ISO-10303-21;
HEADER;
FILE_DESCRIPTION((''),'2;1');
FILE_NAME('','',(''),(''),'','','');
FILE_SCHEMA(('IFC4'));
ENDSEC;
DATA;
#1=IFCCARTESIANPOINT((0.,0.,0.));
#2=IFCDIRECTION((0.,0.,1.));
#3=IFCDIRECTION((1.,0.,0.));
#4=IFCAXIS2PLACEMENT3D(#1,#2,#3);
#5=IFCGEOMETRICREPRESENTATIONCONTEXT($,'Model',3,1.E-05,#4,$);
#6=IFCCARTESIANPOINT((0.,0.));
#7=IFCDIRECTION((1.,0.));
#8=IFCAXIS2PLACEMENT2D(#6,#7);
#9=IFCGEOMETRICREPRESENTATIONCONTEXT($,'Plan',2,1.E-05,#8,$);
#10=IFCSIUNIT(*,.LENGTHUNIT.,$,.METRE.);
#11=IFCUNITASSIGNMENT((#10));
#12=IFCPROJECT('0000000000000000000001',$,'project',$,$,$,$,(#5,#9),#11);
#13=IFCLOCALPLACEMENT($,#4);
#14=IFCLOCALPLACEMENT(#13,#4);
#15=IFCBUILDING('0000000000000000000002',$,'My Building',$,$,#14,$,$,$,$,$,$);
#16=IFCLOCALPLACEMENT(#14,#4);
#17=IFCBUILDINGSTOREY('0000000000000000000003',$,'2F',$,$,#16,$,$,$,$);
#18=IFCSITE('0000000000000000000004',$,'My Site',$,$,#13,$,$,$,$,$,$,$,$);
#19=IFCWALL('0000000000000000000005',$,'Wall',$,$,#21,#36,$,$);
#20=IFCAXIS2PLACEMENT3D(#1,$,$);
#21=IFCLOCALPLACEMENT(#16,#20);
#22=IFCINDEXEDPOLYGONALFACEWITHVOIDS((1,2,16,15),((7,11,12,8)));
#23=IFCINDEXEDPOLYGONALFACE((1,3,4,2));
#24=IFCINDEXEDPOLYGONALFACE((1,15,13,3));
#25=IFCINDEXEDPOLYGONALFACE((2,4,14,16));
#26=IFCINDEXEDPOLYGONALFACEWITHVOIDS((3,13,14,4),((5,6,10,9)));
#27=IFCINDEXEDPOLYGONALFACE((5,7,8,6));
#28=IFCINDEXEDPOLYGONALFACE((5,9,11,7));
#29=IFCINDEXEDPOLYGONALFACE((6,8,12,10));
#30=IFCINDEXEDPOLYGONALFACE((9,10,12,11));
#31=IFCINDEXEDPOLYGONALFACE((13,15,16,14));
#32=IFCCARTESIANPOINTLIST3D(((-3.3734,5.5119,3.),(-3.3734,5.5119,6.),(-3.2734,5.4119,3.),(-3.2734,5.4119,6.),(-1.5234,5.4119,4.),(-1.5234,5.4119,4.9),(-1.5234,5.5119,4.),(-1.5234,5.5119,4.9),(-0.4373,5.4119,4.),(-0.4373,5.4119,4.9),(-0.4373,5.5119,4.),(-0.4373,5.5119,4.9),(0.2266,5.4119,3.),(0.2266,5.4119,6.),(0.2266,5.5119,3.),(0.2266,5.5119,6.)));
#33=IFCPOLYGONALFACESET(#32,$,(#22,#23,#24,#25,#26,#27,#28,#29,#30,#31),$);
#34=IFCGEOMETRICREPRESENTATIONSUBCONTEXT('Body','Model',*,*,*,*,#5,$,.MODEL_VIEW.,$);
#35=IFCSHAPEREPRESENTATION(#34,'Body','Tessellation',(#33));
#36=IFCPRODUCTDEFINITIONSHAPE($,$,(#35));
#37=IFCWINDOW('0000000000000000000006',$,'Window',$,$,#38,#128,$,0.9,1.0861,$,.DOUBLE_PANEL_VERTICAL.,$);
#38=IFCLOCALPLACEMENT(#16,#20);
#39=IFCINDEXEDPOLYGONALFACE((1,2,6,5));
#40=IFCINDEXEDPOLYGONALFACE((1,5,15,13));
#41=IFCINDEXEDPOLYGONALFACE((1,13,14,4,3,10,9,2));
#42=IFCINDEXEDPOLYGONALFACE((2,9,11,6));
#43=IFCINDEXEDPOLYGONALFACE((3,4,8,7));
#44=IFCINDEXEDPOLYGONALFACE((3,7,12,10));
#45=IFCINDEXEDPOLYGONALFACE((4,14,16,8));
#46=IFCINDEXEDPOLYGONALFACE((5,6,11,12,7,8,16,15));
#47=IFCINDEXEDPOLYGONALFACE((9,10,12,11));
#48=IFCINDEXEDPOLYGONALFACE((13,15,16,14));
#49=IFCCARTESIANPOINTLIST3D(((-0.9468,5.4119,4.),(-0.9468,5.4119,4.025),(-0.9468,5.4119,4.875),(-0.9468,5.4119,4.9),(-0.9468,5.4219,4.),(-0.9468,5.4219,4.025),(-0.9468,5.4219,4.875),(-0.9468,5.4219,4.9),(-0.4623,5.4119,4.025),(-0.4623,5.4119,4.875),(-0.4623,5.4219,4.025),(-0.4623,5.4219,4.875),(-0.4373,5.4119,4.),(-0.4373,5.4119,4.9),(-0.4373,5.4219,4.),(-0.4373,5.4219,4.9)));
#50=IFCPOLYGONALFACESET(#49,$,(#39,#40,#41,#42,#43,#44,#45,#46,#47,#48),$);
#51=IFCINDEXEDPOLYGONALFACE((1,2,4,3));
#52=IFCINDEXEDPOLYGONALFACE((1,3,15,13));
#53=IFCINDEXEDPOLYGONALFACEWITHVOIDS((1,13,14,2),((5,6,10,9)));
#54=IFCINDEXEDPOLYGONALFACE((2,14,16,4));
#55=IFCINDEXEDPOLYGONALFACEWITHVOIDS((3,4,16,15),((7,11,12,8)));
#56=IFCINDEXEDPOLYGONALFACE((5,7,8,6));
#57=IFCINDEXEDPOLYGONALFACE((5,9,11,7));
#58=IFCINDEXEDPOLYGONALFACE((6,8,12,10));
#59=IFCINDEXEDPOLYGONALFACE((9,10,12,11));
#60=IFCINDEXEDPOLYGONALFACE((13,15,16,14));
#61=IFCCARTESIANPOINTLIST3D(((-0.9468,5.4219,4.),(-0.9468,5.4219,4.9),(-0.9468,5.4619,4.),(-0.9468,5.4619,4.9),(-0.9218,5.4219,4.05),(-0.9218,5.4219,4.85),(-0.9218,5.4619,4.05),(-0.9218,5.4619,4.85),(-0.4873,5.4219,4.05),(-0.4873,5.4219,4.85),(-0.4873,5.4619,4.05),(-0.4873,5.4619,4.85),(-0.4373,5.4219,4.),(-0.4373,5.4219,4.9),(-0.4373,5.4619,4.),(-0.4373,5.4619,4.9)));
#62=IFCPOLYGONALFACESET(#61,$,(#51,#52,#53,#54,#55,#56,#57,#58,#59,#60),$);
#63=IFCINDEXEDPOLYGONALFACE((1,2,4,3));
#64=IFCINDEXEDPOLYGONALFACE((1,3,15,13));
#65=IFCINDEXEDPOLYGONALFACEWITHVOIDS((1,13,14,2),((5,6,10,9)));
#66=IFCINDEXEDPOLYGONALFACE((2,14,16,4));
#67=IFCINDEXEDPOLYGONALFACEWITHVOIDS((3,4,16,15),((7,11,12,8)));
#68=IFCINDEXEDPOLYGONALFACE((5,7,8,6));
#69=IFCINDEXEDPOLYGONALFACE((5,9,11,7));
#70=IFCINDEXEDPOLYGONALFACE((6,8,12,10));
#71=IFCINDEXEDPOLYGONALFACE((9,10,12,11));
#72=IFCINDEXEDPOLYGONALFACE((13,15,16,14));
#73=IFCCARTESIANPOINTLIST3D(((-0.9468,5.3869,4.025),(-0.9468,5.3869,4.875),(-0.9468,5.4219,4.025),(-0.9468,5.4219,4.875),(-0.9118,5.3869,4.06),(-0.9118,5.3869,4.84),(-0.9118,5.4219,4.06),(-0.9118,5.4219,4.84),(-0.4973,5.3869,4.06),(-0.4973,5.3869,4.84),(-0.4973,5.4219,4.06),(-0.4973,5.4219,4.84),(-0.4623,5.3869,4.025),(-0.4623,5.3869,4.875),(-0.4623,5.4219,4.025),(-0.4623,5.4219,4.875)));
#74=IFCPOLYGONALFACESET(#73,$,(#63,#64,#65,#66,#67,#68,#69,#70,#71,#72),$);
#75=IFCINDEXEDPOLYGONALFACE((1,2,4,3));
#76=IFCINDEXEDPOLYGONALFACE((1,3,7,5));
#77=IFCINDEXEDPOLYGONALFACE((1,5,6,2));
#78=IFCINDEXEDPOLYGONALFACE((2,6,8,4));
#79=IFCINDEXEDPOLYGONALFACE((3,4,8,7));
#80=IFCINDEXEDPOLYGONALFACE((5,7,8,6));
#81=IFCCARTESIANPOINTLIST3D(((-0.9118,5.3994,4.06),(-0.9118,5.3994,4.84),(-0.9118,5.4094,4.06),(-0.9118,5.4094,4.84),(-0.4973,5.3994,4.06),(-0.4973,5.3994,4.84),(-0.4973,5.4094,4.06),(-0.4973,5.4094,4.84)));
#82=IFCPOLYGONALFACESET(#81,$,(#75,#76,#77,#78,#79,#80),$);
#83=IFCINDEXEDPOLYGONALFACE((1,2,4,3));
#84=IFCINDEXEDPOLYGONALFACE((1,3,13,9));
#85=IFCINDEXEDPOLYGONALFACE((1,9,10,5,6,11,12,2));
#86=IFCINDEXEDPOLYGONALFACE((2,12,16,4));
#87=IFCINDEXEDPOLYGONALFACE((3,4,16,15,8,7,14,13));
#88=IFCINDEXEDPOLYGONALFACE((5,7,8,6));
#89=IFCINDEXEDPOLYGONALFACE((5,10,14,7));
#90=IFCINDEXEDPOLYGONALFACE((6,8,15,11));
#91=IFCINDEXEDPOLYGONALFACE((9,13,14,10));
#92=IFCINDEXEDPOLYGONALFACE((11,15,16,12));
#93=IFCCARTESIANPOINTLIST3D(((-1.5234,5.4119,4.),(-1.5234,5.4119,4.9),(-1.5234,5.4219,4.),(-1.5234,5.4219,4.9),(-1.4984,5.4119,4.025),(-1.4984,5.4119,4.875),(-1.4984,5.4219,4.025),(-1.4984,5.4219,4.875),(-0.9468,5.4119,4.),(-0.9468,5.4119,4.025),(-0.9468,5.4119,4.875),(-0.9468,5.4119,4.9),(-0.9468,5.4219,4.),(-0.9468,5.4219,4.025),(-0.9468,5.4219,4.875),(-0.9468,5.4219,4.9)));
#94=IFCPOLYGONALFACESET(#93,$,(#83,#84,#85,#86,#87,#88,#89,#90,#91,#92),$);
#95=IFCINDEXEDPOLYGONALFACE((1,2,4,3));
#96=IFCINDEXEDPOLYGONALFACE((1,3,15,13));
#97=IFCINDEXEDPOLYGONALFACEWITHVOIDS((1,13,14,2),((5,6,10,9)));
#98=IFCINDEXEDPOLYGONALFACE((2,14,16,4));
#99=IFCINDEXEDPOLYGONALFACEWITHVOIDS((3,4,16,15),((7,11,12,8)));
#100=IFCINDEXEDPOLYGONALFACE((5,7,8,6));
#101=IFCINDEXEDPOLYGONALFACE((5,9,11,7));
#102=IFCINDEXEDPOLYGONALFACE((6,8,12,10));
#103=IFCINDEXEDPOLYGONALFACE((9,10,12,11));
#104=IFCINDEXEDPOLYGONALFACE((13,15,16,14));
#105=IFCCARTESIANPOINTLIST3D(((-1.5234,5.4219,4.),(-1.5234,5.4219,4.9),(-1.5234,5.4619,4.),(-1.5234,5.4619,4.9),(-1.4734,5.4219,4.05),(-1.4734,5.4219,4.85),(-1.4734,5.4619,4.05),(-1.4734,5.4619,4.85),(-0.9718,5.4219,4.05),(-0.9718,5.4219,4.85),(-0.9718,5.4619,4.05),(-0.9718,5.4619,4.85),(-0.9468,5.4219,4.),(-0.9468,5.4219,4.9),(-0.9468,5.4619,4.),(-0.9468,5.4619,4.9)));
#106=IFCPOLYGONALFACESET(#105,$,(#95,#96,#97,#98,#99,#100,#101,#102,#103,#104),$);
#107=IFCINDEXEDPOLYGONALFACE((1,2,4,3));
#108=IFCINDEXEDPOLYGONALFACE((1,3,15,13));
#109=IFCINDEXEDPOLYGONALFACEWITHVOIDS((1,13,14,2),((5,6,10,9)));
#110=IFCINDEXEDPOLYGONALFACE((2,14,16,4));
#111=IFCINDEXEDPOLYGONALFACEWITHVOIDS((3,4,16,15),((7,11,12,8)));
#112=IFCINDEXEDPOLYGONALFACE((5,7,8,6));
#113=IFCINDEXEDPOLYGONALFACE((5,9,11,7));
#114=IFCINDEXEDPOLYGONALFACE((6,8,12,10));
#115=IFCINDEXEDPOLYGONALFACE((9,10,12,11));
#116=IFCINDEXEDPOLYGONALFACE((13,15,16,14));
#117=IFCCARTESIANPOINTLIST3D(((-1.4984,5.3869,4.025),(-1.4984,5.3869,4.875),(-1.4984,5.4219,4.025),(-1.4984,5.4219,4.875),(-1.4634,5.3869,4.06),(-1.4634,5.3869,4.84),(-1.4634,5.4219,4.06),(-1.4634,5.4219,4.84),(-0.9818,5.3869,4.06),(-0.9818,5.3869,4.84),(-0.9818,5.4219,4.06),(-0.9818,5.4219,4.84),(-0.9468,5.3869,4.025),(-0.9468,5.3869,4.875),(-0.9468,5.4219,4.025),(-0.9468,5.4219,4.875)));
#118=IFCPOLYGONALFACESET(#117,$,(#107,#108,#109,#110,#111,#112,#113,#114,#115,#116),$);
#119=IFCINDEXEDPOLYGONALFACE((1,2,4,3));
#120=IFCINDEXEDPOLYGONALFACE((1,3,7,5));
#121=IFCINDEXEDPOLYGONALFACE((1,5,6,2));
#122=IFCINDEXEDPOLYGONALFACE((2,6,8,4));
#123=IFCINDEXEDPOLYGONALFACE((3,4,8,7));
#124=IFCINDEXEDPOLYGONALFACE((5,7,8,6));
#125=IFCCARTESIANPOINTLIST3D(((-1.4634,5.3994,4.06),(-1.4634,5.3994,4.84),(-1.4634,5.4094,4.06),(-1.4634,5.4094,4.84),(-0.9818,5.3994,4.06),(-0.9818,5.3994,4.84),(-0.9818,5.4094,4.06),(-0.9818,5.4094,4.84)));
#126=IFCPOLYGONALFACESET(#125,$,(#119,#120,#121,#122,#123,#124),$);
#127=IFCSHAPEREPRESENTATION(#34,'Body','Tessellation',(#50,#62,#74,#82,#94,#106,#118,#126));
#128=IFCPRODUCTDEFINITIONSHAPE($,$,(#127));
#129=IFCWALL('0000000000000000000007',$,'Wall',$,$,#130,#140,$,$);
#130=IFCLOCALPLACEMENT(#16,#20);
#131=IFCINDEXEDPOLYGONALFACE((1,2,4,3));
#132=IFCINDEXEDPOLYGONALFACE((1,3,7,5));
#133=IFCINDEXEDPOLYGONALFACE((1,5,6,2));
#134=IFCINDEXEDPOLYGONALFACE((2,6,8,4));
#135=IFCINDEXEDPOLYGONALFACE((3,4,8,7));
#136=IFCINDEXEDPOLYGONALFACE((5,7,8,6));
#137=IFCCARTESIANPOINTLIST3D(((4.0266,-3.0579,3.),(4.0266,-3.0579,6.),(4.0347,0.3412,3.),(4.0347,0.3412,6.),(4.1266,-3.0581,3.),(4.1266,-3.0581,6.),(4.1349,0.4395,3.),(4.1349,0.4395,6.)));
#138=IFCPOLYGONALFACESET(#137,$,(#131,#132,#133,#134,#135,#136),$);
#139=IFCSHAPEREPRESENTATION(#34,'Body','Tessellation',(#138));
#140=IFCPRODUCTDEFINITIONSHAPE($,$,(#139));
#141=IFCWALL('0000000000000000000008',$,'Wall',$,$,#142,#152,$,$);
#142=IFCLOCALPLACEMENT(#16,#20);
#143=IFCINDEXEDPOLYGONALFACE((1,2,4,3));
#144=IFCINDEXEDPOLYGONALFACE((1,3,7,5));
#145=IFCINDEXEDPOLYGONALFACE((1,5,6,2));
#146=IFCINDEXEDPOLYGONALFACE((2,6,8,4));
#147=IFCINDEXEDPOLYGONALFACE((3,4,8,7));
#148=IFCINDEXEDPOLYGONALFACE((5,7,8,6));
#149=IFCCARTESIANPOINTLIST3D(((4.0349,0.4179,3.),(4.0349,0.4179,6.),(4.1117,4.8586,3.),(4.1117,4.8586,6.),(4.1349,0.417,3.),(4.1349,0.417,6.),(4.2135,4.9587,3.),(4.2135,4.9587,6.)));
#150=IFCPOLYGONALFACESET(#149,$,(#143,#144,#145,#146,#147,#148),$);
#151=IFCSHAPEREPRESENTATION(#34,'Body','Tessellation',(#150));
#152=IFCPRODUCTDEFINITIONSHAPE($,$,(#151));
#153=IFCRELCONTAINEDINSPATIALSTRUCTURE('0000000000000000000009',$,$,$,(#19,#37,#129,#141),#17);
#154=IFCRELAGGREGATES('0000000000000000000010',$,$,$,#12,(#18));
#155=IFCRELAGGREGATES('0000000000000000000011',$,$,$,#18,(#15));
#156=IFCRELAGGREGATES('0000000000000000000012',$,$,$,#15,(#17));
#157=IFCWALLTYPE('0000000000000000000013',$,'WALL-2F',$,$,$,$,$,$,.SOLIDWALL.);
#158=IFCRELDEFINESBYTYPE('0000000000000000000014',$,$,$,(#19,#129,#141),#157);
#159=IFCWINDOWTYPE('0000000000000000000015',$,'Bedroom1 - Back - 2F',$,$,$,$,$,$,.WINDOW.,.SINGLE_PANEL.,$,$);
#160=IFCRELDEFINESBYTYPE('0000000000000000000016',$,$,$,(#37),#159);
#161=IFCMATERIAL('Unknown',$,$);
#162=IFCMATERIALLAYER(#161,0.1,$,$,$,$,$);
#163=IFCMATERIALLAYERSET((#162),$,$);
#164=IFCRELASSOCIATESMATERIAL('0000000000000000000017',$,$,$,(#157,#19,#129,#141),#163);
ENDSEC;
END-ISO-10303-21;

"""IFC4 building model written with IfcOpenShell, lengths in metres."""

from ifc_helpers import new_model, entity, si_unit, frame, origin_with_axes, origin_2d_with_axis, place, context, subcontext, project, spatial, line, indexed_curve, outline, extrude, shape, source, transform, mapped, material, layer, layer_set, layer_usage, type_object, type_shapes, element, fill, save


model = new_model("IFC4")

# Units and contexts
model_context = context("Model", 3, precision=1e-05, world=origin_with_axes())
plan_context = context("Plan", 2, precision=1e-05, world=origin_2d_with_axis())
body_context_1 = subcontext(model_context, "Body", "Model", "MODEL_VIEW")
body_context_2 = subcontext(plan_context, "Body", "Plan", "PLAN_VIEW")
ifc_project = project(units=[si_unit("LENGTHUNIT", "METRE")], contexts=[model_context, plan_context])

# Site, building, storey
site_placement = place(None, origin_with_axes())
site = spatial("IfcSite", under=ifc_project, at=site_placement, Name="My Site")
building_placement = place(site_placement, origin_with_axes())
building = spatial("IfcBuilding", under=site, at=building_placement, Name="My Building")
storey_placement = place(building_placement, origin_with_axes())
storey = spatial("IfcBuildingStorey", under=building, at=storey_placement, Name="2F")

# Shared definitions
ifc_material = material(Name="Unknown")
ifc_layer_1 = layer(ifc_material, 0.1)
ifc_layer_set_1 = layer_set([ifc_layer_1])
wall_type_1 = type_object("IfcWallType", Name="WALL-2F", PredefinedType="SOLIDWALL", material=ifc_layer_set_1)

# Wall, opening, window
ifc_layer_usage_1 = layer_usage(ifc_layer_set_1, "AXIS2", "POSITIVE", 0.0)
wall_1_placement = place(storey_placement, frame((0.2266, 5.5119, 3.0), z_axis=(0.0, 0.0, 1.0), x_axis=(-1.0, 0.0, 0.0)))
wall_1 = element("IfcWall", 1, at=wall_1_placement, inside=storey, type_object=wall_type_1, material=ifc_layer_usage_1, Name="Wall", context=body_context_1, shape_type="SweptSolid", body=[
    extrude(outline(indexed_curve([(0.0, 0.0), (0.0, 0.1), (3.5, 0.1), (3.6, 0.0)], segments=[line(1, 2, 3, 4, 1)])), origin_with_axes(), (0.0, 0.0, 1.0), 3.0),
])
shared_shape_1 = source(origin_with_axes(), body_context_1, "Body", "SweptSolid", [
    extrude(outline(indexed_curve([(0.0, 0.0), (1.0861, 0.0), (1.0861, 0.9), (0.0, 0.9)], segments=[line(1, 2, 3, 4, 1)])), frame((0.0, -0.6, 0.0), z_axis=(0.0, -1.0, 0.0), x_axis=(1.0, 0.0, 0.0)), (0.0, 0.0, -1.0), 1.2),
])
opening_1_placement = place(wall_1_placement, frame((0.6639, 0.0, 1.0), z_axis=(0.0, 0.0, 1.0), x_axis=(1.0, 0.0, 0.0)))
opening_1 = element("IfcOpeningElement", 2, at=opening_1_placement, cuts=wall_1, PredefinedType="OPENING", context=body_context_1, shape_type="MappedRepresentation", body=[
    mapped(shared_shape_1, transform((0.0, 0.0, 0.0), x_axis=(1.0, 0.0, 0.0), y_axis=(0.0, 1.0, 0.0), z_axis=(0.0, 0.0, 1.0), scale=1.0)),
])
window_type_1 = type_object("IfcWindowType", Name="Bedroom1 - Back - 2F", PartitioningType="SINGLE_PANEL", PredefinedType="WINDOW")
shared_shape_2 = source(origin_with_axes(), body_context_1, "Body", "SweptSolid", [
    extrude(outline(indexed_curve([(0.5096, 0.0), (0.0, 0.0), (0.0, 0.9), (0.5096, 0.9), (0.5096, 0.875), (0.025, 0.875), (0.025, 0.025), (0.5096, 0.025)], segments=[line(1, 2, 3, 4, 5, 6, 7, 8, 1)])), frame((0.0, 0.09, 0.0), z_axis=(0.0, -1.0, 0.0), x_axis=(1.0, 0.0, 0.0)), (0.0, 0.0, -1.0), 0.01),
    extrude(outline(indexed_curve([(0.0, 0.0), (0.5096, 0.0), (0.5096, 0.9), (0.0, 0.9)], segments=[line(1, 2, 3, 4, 1)]), holes=[indexed_curve([(0.05, 0.05), (0.4846, 0.05), (0.4846, 0.85), (0.05, 0.85)], segments=[line(1, 2, 3, 4, 1)])]), frame((0.0, 0.05, 0.0), z_axis=(0.0, -1.0, 0.0), x_axis=(1.0, 0.0, 0.0)), (0.0, 0.0, -1.0), 0.04),
    extrude(outline(indexed_curve([(0.0, 0.0), (0.4846, 0.0), (0.4846, 0.85), (0.0, 0.85)], segments=[line(1, 2, 3, 4, 1)]), holes=[indexed_curve([(0.035, 0.035), (0.4496, 0.035), (0.4496, 0.815), (0.035, 0.815)], segments=[line(1, 2, 3, 4, 1)])]), frame((0.025, 0.09, 0.025), z_axis=(0.0, -1.0, 0.0), x_axis=(1.0, 0.0, 0.0)), (0.0, 0.0, -1.0), 0.035),
    extrude(outline(indexed_curve([(0.035, 0.035), (0.4496, 0.035), (0.4496, 0.815), (0.035, 0.815)], segments=[line(1, 2, 3, 4, 1)])), frame((0.025, 0.1025, 0.025), z_axis=(0.0, -1.0, 0.0), x_axis=(1.0, 0.0, 0.0)), (0.0, 0.0, -1.0), 0.01),
    extrude(outline(indexed_curve([(0.0, 0.9), (0.5766, 0.9), (0.5766, 0.0), (0.0, 0.0), (0.0, 0.025), (0.5516, 0.025), (0.5516, 0.875), (0.0, 0.875)], segments=[line(1, 2, 3, 4, 5, 6, 7, 8, 1)])), frame((0.5096, 0.09, 0.0), z_axis=(0.0, -1.0, 0.0), x_axis=(1.0, 0.0, 0.0)), (0.0, 0.0, -1.0), 0.01),
    extrude(outline(indexed_curve([(0.0, 0.0), (0.5766, 0.0), (0.5766, 0.9), (0.0, 0.9)], segments=[line(1, 2, 3, 4, 1)]), holes=[indexed_curve([(0.025, 0.05), (0.5266, 0.05), (0.5266, 0.85), (0.025, 0.85)], segments=[line(1, 2, 3, 4, 1)])]), frame((0.5096, 0.05, 0.0), z_axis=(0.0, -1.0, 0.0), x_axis=(1.0, 0.0, 0.0)), (0.0, 0.0, -1.0), 0.04),
    extrude(outline(indexed_curve([(0.0, 0.0), (0.5516, 0.0), (0.5516, 0.85), (0.0, 0.85)], segments=[line(1, 2, 3, 4, 1)]), holes=[indexed_curve([(0.035, 0.035), (0.5166, 0.035), (0.5166, 0.815), (0.035, 0.815)], segments=[line(1, 2, 3, 4, 1)])]), frame((0.5096, 0.09, 0.025), z_axis=(0.0, -1.0, 0.0), x_axis=(1.0, 0.0, 0.0)), (0.0, 0.0, -1.0), 0.035),
    extrude(outline(indexed_curve([(0.035, 0.035), (0.5166, 0.035), (0.5166, 0.815), (0.035, 0.815)], segments=[line(1, 2, 3, 4, 1)])), frame((0.5096, 0.1025, 0.025), z_axis=(0.0, -1.0, 0.0), x_axis=(1.0, 0.0, 0.0)), (0.0, 0.0, -1.0), 0.01),
])
shared_shape_3 = source(origin_with_axes(), body_context_2, "Body", "Curve2D", [
    entity("IfcIndexedPolyCurve", entity("IfcCartesianPointList2D", [[0.05, 0.05], [0.4846, 0.05]])),
    entity("IfcIndexedPolyCurve", entity("IfcCartesianPointList2D", [[0.0, 0.1], [0.025, 0.1], [0.025, 0.09], [0.05, 0.09], [0.05, 0.05], [0.0, 0.05]]), [entity("IfcLineIndex", [1, 2, 3, 4, 5, 6, 1])]),
    entity("IfcIndexedPolyCurve", entity("IfcCartesianPointList2D", [[0.5096, 0.1], [0.5096, 0.1], [0.5096, 0.09], [0.4846, 0.09], [0.4846, 0.05], [0.5096, 0.05]])),
    entity("IfcIndexedPolyCurve", entity("IfcCartesianPointList2D", [[0.025, 0.09], [0.06, 0.09], [0.06, 0.125], [0.025, 0.125]]), [entity("IfcLineIndex", [1, 2, 3, 4, 1])]),
    entity("IfcIndexedPolyCurve", entity("IfcCartesianPointList2D", [[0.5096, 0.09], [0.4746, 0.09], [0.4746, 0.125], [0.5096, 0.125]]), [entity("IfcLineIndex", [1, 2, 3, 4, 1])]),
    entity("IfcIndexedPolyCurve", entity("IfcCartesianPointList2D", [[0.06, 0.09], [0.4746, 0.09]])),
    entity("IfcIndexedPolyCurve", entity("IfcCartesianPointList2D", [[0.06, 0.125], [0.4746, 0.125]])),
    entity("IfcIndexedPolyCurve", entity("IfcCartesianPointList2D", [[0.06, 0.1075], [0.4746, 0.1075]])),
    entity("IfcIndexedPolyCurve", entity("IfcCartesianPointList2D", [[0.5346, 0.05], [1.0361, 0.05]])),
    entity("IfcIndexedPolyCurve", entity("IfcCartesianPointList2D", [[0.5096, 0.1], [0.5096, 0.1], [0.5096, 0.09], [0.5346, 0.09], [0.5346, 0.05], [0.5096, 0.05]])),
    entity("IfcIndexedPolyCurve", entity("IfcCartesianPointList2D", [[1.0861, 0.1], [1.0611, 0.1], [1.0611, 0.09], [1.0361, 0.09], [1.0361, 0.05], [1.0861, 0.05]]), [entity("IfcLineIndex", [1, 2, 3, 4, 5, 6, 1])]),
    entity("IfcIndexedPolyCurve", entity("IfcCartesianPointList2D", [[0.5096, 0.09], [0.5446, 0.09], [0.5446, 0.125], [0.5096, 0.125]]), [entity("IfcLineIndex", [1, 2, 3, 4, 1])]),
    entity("IfcIndexedPolyCurve", entity("IfcCartesianPointList2D", [[1.0611, 0.09], [1.0261, 0.09], [1.0261, 0.125], [1.0611, 0.125]]), [entity("IfcLineIndex", [1, 2, 3, 4, 1])]),
    entity("IfcIndexedPolyCurve", entity("IfcCartesianPointList2D", [[0.5446, 0.09], [1.0261, 0.09]])),
    entity("IfcIndexedPolyCurve", entity("IfcCartesianPointList2D", [[0.5446, 0.125], [1.0261, 0.125]])),
    entity("IfcIndexedPolyCurve", entity("IfcCartesianPointList2D", [[0.5446, 0.1075], [1.0261, 0.1075]])),
])
type_shapes(window_type_1, [shared_shape_2, shared_shape_3])
window_1_placement = place(opening_1_placement, frame((0.0, 0.0, 0.0), z_axis=(0.0, 0.0, 1.0), x_axis=(1.0, 0.0, 0.0)))
window_1 = element("IfcWindow", 3, at=window_1_placement, inside=storey, type_object=window_type_1, Name="Window", OverallHeight=0.9, OverallWidth=1.0861, PartitioningType="DOUBLE_PANEL_VERTICAL", shapes=[
    shape(body_context_1, "Body", "MappedRepresentation", [mapped(shared_shape_2, transform((0.0, 0.0, 0.0), x_axis=(1.0, 0.0, 0.0), y_axis=(0.0, 1.0, 0.0), z_axis=(0.0, 0.0, 1.0), scale=1.0))]),
    shape(body_context_2, "Body", "MappedRepresentation", [mapped(shared_shape_3, transform((0.0, 0.0, 0.0), x_axis=(1.0, 0.0, 0.0), y_axis=(0.0, 1.0, 0.0), z_axis=(0.0, 0.0, 1.0), scale=1.0))]),
])
fill(opening_1, window_1)

# Walls
ifc_layer_usage_2 = layer_usage(ifc_layer_set_1, "AXIS2", "POSITIVE", 0.0)
wall_2_placement = place(storey_placement, frame((4.1266, -3.0581, 3.0), z_axis=(0.0, 0.0, 1.0), x_axis=(0.002384, 0.999997, 0.0)))
element("IfcWall", 4, at=wall_2_placement, inside=storey, type_object=wall_type_1, material=ifc_layer_usage_2, Name="Wall", context=body_context_1, shape_type="SweptSolid", body=[
    extrude(outline(indexed_curve([(0.0, 0.0), (0.0, 0.1), (3.3991, 0.1), (3.4976, 0.0)], segments=[line(1, 2, 3, 4, 1)])), origin_with_axes(), (0.0, 0.0, 1.0), 3.0),
])
ifc_layer_usage_3 = layer_usage(ifc_layer_set_1, "AXIS2", "POSITIVE", 0.0)
wall_3_placement = place(storey_placement, frame((4.1349, 0.417, 3.0), z_axis=(0.0, 0.0, 1.0), x_axis=(0.017301, 0.99985, 0.0)))
element("IfcWall", 5, at=wall_3_placement, inside=storey, type_object=wall_type_1, material=ifc_layer_usage_3, Name="Wall", context=body_context_1, shape_type="SweptSolid", body=[
    extrude(outline(indexed_curve([(0.0, 0.0), (-0.0007, 0.1), (4.4406, 0.1), (4.5424, 0.0)], segments=[line(1, 2, 3, 4, 1)])), origin_with_axes(), (0.0, 0.0, 1.0), 3.0),
])

save(model, "model.ifc")
